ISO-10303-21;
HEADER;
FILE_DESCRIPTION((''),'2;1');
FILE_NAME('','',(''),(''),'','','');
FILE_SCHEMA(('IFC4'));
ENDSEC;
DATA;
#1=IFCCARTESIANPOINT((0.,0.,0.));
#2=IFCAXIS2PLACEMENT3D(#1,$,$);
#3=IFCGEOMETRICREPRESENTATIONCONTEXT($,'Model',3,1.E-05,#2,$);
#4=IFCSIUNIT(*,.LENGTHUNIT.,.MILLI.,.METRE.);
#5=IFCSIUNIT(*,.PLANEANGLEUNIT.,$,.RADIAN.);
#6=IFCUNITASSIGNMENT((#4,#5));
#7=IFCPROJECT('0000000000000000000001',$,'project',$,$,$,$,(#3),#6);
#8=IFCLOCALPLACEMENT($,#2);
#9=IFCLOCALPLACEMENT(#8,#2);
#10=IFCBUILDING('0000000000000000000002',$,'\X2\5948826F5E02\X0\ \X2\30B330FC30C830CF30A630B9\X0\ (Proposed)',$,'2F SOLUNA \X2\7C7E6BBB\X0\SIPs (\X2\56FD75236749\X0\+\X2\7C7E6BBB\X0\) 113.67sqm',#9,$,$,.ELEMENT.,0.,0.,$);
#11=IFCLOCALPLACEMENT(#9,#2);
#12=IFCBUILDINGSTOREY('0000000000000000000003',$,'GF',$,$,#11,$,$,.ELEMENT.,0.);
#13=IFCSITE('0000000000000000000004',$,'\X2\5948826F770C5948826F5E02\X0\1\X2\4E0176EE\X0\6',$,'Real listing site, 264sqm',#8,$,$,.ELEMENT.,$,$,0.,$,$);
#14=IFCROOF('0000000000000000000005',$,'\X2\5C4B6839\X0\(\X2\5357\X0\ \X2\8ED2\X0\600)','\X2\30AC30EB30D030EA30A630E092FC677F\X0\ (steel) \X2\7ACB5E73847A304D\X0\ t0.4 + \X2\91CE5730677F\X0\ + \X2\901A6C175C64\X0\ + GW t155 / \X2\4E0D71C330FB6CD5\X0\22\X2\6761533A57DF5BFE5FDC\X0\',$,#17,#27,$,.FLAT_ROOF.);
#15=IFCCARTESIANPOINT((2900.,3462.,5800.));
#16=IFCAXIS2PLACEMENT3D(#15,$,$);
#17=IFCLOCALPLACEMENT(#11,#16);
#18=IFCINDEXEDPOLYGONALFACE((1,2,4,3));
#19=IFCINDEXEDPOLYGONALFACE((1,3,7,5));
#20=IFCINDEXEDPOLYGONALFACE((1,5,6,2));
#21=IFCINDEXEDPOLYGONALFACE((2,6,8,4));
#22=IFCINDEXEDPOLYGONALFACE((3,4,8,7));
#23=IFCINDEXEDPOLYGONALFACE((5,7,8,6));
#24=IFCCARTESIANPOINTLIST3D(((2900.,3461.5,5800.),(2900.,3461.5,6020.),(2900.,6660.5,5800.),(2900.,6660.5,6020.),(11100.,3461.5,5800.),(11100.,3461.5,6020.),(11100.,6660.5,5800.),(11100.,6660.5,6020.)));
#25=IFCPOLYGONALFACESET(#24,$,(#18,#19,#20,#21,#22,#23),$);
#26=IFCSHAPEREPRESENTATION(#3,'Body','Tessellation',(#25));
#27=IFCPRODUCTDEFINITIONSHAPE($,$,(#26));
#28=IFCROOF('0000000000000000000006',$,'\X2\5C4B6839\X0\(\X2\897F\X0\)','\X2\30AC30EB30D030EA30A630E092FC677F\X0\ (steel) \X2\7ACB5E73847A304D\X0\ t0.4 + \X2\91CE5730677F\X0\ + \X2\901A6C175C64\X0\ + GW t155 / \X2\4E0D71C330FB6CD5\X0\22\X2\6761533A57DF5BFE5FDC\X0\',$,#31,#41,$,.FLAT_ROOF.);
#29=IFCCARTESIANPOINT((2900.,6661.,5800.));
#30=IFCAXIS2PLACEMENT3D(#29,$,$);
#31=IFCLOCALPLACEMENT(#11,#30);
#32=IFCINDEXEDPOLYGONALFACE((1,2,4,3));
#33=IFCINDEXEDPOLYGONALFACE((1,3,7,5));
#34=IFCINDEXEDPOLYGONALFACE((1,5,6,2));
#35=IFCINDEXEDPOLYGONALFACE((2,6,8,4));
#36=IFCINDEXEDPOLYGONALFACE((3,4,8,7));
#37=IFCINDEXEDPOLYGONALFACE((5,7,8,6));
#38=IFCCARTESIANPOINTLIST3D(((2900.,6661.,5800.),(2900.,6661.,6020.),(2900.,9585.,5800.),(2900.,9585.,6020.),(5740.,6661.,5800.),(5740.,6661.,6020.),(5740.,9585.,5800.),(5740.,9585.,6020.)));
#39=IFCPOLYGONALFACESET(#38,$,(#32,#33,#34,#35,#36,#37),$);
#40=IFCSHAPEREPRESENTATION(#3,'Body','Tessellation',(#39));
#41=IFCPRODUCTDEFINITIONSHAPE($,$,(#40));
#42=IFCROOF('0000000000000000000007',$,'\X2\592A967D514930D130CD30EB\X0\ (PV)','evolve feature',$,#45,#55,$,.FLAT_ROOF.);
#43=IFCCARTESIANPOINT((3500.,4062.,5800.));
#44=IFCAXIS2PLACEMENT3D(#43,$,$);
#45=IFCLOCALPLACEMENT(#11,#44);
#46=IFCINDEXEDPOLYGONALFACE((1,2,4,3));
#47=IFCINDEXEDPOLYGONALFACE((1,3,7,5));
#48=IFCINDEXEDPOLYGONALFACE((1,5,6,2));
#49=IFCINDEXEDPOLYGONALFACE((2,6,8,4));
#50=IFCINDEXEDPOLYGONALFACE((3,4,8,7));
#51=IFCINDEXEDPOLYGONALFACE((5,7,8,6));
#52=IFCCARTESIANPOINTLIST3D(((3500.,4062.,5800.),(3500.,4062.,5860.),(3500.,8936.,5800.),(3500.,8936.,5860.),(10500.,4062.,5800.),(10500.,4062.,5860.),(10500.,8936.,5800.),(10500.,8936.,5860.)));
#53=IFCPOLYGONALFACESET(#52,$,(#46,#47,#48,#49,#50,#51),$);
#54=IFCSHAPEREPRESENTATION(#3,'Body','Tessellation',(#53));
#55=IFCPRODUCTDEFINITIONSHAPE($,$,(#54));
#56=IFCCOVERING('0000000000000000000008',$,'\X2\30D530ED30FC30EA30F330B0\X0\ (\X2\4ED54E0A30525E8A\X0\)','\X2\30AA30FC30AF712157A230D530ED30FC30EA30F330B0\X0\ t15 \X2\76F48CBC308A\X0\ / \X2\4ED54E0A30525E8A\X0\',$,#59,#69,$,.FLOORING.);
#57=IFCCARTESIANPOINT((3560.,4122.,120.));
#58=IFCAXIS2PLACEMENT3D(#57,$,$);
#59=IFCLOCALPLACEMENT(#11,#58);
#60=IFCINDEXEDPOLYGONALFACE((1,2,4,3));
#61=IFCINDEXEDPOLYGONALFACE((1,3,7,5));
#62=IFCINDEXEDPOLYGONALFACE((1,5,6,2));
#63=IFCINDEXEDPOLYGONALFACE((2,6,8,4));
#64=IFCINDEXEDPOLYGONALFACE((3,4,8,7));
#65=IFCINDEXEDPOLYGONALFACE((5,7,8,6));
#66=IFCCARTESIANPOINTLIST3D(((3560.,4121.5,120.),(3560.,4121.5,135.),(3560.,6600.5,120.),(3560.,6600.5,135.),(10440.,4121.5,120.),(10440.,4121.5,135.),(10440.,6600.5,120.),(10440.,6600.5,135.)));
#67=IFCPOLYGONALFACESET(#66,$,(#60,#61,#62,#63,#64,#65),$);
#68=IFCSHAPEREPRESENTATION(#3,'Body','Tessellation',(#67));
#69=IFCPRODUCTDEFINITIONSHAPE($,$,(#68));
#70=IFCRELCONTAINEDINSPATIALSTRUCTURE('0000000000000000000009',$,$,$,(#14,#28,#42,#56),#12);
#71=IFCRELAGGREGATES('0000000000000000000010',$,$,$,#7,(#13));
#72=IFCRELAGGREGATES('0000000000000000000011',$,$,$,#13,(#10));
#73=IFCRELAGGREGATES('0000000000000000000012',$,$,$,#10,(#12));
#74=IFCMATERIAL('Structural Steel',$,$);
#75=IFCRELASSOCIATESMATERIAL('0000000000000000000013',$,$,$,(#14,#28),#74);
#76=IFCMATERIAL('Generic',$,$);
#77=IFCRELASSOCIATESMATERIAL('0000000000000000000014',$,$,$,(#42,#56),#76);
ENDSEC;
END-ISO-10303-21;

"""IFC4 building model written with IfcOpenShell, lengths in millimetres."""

from ifc_helpers import new_model, si_unit, frame, frame_2d, origin, place, context, project, spatial, rectangle, extrude, material, element, save


model = new_model("IFC4")

# Units and contexts
model_context = context("Model", 3, precision=1e-05, world=origin())
ifc_project = project(units=[si_unit("LENGTHUNIT", "METRE", prefix="MILLI"), si_unit("PLANEANGLEUNIT", "RADIAN")], contexts=[model_context])

# Site, building, storey
site_placement = place(None, origin())
site = spatial("IfcSite", under=ifc_project, at=site_placement, Name="奈良県奈良市1丁目6", ObjectType="Real listing site, 264sqm", CompositionType="ELEMENT", RefElevation=0.0)
building_placement = place(site_placement, origin())
building = spatial("IfcBuilding", under=site, at=building_placement, Name="奈良市 コートハウス (Proposed)", ObjectType="2F SOLUNA 籾殻SIPs (国産杉+籾殻) 113.67sqm", CompositionType="ELEMENT", ElevationOfRefHeight=0.0, ElevationOfTerrain=0.0)
storey_placement = place(building_placement, origin())
storey = spatial("IfcBuildingStorey", under=building, at=storey_placement, Name="GF", CompositionType="ELEMENT", Elevation=0.0)

# Shared definitions
ifc_material_1 = material(Name="Generic")

# Roofs
ifc_material_2 = material(Name="Structural Steel")
roof_1_placement = place(storey_placement, frame((2900.0, 3462.0, 5800.0)))
element("IfcRoof", 1, at=roof_1_placement, inside=storey, material=ifc_material_2, Name="屋根(南 軒600)", Description="ガルバリウム鋼板 (steel) 立平葺き t0.4 + 野地板 + 通気層 + GW t155 / 不燃・法22条区域対応", PredefinedType="FLAT_ROOF", context=model_context, shape_type="SweptSolid", body=[
    extrude(rectangle(XDim=8200.0, YDim=3199.0, at=frame_2d((4100.0, 1599.0))), frame((2900.0, 3462.0, 5800.0)), (0.0, 0.0, 1.0), 220.0),
])
roof_2_placement = place(storey_placement, frame((2900.0, 6661.0, 5800.0)))
element("IfcRoof", 2, at=roof_2_placement, inside=storey, material=ifc_material_2, Name="屋根(西)", Description="ガルバリウム鋼板 (steel) 立平葺き t0.4 + 野地板 + 通気層 + GW t155 / 不燃・法22条区域対応", PredefinedType="FLAT_ROOF", context=model_context, shape_type="SweptSolid", body=[
    extrude(rectangle(XDim=2840.0, YDim=2924.0, at=frame_2d((1420.0, 1462.0))), frame((2900.0, 6661.0, 5800.0)), (0.0, 0.0, 1.0), 220.0),
])
roof_3_placement = place(storey_placement, frame((3500.0, 4062.0, 5800.0)))
element("IfcRoof", 3, at=roof_3_placement, inside=storey, material=ifc_material_1, Name="太陽光パネル (PV)", Description="evolve feature", PredefinedType="FLAT_ROOF", context=model_context, shape_type="SweptSolid", body=[
    extrude(rectangle(XDim=7000.0, YDim=4874.0, at=frame_2d((3500.0, 2437.0))), frame((3500.0, 4062.0, 5800.0)), (0.0, 0.0, 1.0), 60.0),
])

# Covering
covering_placement = place(storey_placement, frame((3560.0, 4122.0, 120.0)))
element("IfcCovering", 4, at=covering_placement, inside=storey, material=ifc_material_1, Name="フローリング (仕上げ床)", Description="オーク無垢フローリング t15 直貼り / 仕上げ床", PredefinedType="FLOORING", context=model_context, shape_type="SweptSolid", body=[
    extrude(rectangle(XDim=6880.0, YDim=2479.0, at=frame_2d((3440.0, 1239.0))), frame((3560.0, 4122.0, 120.0)), (0.0, 0.0, 1.0), 15.0),
])

save(model, "model.ifc")
